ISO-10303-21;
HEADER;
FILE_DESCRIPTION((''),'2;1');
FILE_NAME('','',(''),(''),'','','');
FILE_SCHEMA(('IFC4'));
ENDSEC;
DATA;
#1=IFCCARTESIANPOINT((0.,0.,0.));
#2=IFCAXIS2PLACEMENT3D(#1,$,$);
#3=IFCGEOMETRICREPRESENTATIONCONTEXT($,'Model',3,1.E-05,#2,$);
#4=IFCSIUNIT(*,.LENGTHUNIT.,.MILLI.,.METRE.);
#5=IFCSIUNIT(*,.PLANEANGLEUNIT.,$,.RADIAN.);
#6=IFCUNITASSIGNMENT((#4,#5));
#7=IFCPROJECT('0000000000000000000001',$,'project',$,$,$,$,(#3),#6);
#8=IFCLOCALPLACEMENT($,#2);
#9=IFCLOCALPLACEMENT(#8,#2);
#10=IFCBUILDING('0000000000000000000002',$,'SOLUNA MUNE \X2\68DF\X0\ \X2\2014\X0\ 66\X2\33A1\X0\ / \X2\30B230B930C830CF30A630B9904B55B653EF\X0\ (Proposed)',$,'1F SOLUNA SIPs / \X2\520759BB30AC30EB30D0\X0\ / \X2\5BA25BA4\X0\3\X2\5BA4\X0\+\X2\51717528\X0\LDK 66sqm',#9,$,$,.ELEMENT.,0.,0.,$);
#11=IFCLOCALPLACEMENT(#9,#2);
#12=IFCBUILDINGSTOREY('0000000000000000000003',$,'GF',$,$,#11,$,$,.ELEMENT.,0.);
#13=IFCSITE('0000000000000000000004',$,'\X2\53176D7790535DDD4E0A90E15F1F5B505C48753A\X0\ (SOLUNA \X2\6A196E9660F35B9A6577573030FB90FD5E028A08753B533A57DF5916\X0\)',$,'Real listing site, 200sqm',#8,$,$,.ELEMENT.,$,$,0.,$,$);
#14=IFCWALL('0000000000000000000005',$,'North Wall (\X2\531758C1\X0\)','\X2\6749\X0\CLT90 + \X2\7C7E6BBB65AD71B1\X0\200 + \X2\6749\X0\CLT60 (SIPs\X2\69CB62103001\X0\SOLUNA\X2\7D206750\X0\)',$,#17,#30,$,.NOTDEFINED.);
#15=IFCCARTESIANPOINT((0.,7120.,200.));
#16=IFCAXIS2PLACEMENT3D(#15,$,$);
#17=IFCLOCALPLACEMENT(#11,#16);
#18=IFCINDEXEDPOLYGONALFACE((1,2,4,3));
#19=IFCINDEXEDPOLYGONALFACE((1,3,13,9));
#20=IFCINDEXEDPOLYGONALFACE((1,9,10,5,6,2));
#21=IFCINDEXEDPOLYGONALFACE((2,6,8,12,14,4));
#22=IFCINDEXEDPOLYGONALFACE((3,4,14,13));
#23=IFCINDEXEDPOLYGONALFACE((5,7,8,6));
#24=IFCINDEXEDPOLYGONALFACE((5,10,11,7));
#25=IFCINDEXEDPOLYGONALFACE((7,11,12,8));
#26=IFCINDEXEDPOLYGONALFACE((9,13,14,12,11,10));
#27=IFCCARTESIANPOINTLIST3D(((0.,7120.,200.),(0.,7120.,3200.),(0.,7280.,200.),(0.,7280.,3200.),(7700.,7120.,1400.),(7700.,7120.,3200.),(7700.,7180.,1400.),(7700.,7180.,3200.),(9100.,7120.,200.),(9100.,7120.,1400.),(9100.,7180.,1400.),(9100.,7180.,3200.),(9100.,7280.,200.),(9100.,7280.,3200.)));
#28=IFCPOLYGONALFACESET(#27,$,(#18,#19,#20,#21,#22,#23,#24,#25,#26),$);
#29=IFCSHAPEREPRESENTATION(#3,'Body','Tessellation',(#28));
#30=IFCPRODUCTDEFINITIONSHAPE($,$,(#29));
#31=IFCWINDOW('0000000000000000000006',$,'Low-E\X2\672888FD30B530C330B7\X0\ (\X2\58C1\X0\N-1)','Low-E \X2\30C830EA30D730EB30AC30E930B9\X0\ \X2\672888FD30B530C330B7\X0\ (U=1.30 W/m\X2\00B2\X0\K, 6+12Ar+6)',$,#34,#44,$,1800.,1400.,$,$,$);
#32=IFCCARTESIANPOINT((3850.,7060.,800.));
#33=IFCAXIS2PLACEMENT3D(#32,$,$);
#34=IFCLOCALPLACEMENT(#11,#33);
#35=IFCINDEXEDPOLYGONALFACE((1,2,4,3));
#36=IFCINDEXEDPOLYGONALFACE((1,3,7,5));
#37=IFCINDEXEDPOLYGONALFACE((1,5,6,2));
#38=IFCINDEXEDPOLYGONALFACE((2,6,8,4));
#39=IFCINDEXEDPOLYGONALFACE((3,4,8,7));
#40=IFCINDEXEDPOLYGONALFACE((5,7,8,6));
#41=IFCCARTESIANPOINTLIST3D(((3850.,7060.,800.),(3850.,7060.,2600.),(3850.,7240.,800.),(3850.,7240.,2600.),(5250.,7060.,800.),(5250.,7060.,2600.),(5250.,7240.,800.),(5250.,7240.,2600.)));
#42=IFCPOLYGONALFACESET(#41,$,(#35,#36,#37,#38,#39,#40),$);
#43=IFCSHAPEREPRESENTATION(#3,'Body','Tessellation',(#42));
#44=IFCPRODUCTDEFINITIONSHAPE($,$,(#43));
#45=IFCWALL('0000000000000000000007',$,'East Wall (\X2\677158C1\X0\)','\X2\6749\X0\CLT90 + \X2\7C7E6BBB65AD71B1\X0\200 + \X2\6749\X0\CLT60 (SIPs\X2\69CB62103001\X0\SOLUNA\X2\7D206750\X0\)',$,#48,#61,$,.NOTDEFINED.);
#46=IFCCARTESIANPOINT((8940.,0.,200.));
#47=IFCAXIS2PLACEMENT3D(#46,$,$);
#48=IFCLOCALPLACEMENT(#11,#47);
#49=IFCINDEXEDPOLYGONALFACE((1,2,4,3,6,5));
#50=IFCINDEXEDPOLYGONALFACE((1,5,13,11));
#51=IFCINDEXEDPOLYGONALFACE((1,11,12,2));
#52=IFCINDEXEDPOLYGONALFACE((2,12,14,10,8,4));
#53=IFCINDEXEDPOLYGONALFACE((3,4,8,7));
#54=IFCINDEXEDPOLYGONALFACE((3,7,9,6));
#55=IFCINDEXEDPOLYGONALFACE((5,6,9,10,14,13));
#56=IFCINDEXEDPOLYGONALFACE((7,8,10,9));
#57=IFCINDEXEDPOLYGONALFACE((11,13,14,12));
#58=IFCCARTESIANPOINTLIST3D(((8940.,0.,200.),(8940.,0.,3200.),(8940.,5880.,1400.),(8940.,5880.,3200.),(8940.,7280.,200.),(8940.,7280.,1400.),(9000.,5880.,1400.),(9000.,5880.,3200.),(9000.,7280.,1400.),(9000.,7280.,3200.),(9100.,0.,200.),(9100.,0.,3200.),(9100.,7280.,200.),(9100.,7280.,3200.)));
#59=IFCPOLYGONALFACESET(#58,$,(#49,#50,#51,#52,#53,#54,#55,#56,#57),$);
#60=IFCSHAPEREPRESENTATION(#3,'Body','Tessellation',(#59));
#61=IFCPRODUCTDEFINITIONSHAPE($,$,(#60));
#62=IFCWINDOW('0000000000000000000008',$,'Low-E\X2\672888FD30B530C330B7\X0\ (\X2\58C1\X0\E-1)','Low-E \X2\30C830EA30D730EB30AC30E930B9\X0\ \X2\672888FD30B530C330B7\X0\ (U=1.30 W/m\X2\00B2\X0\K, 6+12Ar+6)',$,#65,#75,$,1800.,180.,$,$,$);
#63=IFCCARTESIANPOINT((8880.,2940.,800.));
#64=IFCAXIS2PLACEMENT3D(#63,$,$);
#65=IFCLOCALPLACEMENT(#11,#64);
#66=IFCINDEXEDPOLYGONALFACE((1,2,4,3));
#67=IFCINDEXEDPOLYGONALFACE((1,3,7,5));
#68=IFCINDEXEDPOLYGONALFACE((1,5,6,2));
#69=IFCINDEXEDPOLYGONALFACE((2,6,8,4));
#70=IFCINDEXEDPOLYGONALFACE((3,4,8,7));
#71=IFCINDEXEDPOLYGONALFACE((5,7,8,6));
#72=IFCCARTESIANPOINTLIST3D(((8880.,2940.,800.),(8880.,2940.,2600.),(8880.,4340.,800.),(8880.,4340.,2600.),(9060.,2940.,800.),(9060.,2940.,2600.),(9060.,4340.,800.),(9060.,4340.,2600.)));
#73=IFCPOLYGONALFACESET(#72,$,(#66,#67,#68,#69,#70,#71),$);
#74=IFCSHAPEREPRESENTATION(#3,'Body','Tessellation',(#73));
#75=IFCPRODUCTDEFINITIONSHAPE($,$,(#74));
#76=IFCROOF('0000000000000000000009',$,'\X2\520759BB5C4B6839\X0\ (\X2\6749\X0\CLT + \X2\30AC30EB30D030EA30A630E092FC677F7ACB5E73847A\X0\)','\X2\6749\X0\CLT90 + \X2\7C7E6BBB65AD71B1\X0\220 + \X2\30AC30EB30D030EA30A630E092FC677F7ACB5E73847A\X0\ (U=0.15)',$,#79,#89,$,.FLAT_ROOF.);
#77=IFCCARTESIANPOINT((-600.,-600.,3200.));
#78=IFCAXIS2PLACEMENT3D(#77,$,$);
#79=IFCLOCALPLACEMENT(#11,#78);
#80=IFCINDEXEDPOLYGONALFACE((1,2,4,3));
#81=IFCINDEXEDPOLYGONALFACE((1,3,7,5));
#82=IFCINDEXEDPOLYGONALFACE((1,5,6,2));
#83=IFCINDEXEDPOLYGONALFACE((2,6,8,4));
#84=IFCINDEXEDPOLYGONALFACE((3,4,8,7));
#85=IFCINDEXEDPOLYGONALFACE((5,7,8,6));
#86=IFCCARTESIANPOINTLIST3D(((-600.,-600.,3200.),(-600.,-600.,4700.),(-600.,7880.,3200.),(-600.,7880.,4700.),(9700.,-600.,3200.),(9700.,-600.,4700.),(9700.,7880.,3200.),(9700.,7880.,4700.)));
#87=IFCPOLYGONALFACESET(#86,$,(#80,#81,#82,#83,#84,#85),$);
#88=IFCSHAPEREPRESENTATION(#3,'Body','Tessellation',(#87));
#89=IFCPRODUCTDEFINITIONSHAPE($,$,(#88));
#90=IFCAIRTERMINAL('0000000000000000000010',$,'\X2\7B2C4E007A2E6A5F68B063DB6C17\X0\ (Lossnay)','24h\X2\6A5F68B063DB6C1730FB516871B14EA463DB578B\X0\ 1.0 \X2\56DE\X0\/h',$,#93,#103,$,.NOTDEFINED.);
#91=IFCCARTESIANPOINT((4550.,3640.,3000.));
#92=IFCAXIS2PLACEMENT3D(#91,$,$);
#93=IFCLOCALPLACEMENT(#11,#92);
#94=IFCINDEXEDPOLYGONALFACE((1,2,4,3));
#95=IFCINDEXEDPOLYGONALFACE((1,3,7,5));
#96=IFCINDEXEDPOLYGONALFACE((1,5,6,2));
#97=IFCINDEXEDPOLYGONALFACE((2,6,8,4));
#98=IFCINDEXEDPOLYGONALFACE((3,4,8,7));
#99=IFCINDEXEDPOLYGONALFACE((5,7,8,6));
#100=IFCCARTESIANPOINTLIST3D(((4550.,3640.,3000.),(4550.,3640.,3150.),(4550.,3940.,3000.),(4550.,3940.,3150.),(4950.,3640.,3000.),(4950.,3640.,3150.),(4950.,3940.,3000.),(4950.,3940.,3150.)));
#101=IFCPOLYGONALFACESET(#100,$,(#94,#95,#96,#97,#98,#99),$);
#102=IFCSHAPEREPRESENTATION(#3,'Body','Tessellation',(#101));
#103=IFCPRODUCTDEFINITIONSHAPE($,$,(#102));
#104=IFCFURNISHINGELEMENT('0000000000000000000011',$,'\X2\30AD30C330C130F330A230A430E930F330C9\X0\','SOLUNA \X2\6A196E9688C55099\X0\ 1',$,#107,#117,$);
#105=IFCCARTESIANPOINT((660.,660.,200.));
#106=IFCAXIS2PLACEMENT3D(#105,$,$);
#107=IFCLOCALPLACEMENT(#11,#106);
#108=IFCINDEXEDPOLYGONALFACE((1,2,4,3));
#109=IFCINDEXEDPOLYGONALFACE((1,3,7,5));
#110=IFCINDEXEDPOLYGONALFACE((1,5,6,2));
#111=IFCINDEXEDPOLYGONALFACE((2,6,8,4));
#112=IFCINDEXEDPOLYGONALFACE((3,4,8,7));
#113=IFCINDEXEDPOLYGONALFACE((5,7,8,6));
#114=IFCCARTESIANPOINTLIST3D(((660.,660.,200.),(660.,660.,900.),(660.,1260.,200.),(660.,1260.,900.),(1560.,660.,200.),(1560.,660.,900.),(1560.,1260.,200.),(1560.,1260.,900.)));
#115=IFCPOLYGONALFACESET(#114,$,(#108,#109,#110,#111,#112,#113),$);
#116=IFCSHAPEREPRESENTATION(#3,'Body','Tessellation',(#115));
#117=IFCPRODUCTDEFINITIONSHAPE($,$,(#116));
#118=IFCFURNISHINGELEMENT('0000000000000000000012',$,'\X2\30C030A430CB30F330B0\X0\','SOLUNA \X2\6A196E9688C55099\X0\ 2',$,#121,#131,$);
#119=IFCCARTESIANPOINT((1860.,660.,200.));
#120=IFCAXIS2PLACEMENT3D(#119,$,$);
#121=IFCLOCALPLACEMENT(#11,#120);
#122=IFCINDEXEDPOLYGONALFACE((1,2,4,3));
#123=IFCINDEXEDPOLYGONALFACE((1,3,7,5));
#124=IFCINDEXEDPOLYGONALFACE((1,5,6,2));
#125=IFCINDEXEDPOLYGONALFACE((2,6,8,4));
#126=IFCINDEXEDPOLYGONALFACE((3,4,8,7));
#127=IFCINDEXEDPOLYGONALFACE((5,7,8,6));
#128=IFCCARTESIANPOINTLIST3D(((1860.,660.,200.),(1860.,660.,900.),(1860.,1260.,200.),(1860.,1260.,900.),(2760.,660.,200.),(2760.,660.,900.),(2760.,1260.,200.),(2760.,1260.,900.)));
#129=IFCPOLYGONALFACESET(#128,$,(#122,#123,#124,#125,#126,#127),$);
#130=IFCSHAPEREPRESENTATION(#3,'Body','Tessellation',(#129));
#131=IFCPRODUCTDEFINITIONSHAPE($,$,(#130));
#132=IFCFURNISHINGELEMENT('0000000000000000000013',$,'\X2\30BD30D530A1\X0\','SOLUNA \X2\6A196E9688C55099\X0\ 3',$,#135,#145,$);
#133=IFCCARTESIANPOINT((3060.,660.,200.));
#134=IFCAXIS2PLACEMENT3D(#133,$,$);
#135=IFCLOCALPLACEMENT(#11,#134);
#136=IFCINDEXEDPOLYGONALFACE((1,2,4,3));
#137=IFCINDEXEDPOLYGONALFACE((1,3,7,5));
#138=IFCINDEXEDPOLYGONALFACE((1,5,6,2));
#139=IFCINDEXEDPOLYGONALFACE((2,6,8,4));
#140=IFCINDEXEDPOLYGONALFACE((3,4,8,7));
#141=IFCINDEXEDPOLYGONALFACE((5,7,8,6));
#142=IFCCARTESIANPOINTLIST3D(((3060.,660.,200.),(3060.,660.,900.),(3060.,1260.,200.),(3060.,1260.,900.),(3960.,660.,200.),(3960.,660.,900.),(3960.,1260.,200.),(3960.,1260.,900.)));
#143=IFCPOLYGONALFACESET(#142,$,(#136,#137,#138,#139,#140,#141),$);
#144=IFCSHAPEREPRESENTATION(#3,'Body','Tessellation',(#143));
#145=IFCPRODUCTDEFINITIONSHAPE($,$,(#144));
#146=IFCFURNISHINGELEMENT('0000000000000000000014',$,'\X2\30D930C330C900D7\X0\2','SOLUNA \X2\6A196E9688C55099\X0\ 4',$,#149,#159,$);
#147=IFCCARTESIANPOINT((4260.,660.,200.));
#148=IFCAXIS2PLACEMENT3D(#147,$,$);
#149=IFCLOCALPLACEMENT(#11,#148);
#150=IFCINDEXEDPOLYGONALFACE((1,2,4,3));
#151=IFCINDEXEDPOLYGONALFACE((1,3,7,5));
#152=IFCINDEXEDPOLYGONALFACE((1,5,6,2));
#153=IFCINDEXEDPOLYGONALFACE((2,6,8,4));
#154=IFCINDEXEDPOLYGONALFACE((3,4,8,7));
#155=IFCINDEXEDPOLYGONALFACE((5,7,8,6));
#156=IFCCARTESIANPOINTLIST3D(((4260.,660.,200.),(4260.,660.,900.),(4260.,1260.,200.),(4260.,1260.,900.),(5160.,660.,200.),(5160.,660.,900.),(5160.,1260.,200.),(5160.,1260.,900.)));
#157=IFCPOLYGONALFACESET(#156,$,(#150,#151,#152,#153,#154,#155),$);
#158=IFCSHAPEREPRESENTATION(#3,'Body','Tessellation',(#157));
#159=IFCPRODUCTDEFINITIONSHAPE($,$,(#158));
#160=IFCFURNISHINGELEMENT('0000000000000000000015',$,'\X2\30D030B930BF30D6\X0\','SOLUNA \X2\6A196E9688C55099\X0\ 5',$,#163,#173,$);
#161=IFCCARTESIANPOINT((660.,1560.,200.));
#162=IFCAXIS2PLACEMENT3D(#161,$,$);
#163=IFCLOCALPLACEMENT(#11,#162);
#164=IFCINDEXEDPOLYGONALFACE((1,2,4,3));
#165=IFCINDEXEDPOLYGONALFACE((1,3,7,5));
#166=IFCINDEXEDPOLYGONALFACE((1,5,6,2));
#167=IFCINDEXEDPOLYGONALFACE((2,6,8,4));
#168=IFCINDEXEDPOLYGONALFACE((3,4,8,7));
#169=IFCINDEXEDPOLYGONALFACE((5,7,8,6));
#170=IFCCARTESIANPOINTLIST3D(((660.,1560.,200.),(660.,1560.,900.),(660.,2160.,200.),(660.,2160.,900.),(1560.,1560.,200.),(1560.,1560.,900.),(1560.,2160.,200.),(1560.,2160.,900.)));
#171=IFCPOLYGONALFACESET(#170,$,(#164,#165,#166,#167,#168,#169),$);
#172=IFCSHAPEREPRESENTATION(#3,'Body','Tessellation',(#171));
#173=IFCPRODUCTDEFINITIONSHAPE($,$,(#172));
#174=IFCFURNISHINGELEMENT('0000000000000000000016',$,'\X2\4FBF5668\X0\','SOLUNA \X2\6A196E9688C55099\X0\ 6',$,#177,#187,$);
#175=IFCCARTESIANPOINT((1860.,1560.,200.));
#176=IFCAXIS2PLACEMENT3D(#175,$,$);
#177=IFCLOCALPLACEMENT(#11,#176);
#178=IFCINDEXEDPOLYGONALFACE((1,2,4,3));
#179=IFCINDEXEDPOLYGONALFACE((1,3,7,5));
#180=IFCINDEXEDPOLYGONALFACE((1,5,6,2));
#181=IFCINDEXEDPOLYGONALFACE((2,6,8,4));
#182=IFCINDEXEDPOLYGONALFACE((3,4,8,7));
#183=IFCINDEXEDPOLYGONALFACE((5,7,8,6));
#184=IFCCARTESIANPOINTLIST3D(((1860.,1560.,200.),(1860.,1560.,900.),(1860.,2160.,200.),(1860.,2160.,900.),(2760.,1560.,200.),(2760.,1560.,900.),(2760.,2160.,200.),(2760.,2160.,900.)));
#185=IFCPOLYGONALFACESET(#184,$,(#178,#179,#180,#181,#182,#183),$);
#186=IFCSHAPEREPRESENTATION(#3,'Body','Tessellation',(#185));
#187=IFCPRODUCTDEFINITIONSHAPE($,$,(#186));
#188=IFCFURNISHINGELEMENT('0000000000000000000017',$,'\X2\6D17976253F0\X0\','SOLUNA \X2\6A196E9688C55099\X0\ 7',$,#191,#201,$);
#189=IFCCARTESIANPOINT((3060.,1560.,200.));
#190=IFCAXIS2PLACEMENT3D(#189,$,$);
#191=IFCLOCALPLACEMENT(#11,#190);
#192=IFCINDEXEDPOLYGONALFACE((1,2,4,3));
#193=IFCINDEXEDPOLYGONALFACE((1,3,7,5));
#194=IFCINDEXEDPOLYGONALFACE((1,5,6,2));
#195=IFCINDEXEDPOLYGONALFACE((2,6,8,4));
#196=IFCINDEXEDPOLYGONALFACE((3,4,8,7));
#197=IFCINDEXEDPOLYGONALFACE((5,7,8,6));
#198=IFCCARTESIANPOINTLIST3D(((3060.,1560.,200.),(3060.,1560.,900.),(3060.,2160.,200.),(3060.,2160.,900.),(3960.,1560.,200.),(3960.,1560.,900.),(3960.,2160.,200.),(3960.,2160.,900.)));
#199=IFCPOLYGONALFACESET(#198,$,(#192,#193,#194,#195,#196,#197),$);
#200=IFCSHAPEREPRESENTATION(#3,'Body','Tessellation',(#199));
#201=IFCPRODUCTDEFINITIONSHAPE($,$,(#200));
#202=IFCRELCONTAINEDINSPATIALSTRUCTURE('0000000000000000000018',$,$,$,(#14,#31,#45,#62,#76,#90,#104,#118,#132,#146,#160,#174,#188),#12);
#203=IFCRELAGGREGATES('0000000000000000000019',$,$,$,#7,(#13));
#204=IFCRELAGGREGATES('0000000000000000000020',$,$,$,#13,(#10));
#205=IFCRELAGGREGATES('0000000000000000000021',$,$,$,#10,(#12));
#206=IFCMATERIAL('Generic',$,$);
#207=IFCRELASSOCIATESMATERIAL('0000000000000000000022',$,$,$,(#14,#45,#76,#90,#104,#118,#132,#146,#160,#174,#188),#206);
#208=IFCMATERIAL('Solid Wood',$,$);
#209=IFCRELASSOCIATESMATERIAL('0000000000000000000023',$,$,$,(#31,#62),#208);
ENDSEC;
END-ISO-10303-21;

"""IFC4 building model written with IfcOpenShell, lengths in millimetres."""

from ifc_helpers import new_model, si_unit, frame, frame_2d, origin, place, context, project, spatial, rectangle, extrude, material, element, fill, save


model = new_model("IFC4")

# Units and contexts
model_context = context("Model", 3, precision=1e-05, world=origin())
ifc_project = project(units=[si_unit("LENGTHUNIT", "METRE", prefix="MILLI"), si_unit("PLANEANGLEUNIT", "RADIAN")], contexts=[model_context])

# Site, building, storey
site_placement = place(None, origin())
site = spatial("IfcSite", under=ifc_project, at=site_placement, Name="北海道川上郡弟子屈町 (SOLUNA 標準想定敷地・都市計画区域外)", ObjectType="Real listing site, 200sqm", CompositionType="ELEMENT", RefElevation=0.0)
building_placement = place(site_placement, origin())
building = spatial("IfcBuilding", under=site, at=building_placement, Name="SOLUNA MUNE 棟 — 66㎡ / ゲストハウス運営可 (Proposed)", ObjectType="1F SOLUNA SIPs / 切妻ガルバ / 客室3室+共用LDK 66sqm", CompositionType="ELEMENT", ElevationOfRefHeight=0.0, ElevationOfTerrain=0.0)
storey_placement = place(building_placement, origin())
storey = spatial("IfcBuildingStorey", under=building, at=storey_placement, Name="GF", CompositionType="ELEMENT", Elevation=0.0)

# Shared definitions
ifc_material_1 = material(Name="Generic")

# Shared definitions
ifc_material_2 = material(Name="Solid Wood")

# Walls, openings, windows
wall_1_placement = place(storey_placement, frame((0.0, 7120.0, 200.0)))
wall_1 = element("IfcWall", 1, at=wall_1_placement, inside=storey, material=ifc_material_1, Name="North Wall (北壁)", Description="杉CLT90 + 籾殻断熱200 + 杉CLT60 (SIPs構成、SOLUNA素材)", PredefinedType="NOTDEFINED", context=model_context, shape_type="SweptSolid", body=[
    extrude(rectangle(XDim=9100.0, YDim=160.0, at=frame_2d((4550.0, 80.0))), frame((0.0, 7120.0, 200.0)), (0.0, 0.0, 1.0), 3000.0),
])
opening_1_placement = place(storey_placement, frame((3850.0, 7060.0, 800.0)))
opening_1 = element("IfcOpeningElement", 2, at=opening_1_placement, cuts=wall_1, PredefinedType="NOTDEFINED", context=model_context, shape_type="SweptSolid", body=[
    extrude(rectangle(XDim=1400.0, YDim=180.0, at=frame_2d((700.0, 90.0))), frame((3850.0, 7060.0, 800.0)), (0.0, 0.0, 1.0), 1800.0),
])
window_1_placement = place(storey_placement, frame((3850.0, 7060.0, 800.0)))
window_1 = element("IfcWindow", 3, at=window_1_placement, inside=storey, material=ifc_material_2, Name="Low-E木製サッシ (壁N-1)", Description="Low-E トリプルガラス 木製サッシ (U=1.30 W/m²K, 6+12Ar+6)", OverallHeight=1800.0, OverallWidth=1400.0, context=model_context, shape_type="SweptSolid", body=[
    extrude(rectangle(XDim=1400.0, YDim=180.0, at=frame_2d((700.0, 90.0))), frame((3850.0, 7060.0, 800.0)), (0.0, 0.0, 1.0), 1800.0),
])
fill(opening_1, window_1)
wall_2_placement = place(storey_placement, frame((8940.0, 0.0, 200.0)))
wall_2 = element("IfcWall", 4, at=wall_2_placement, inside=storey, material=ifc_material_1, Name="East Wall (東壁)", Description="杉CLT90 + 籾殻断熱200 + 杉CLT60 (SIPs構成、SOLUNA素材)", PredefinedType="NOTDEFINED", context=model_context, shape_type="SweptSolid", body=[
    extrude(rectangle(XDim=160.0, YDim=7280.0, at=frame_2d((80.0, 3640.0))), frame((8940.0, 0.0, 200.0)), (0.0, 0.0, 1.0), 3000.0),
])
opening_2_placement = place(storey_placement, frame((8880.0, 2940.0, 800.0)))
opening_2 = element("IfcOpeningElement", 5, at=opening_2_placement, cuts=wall_2, PredefinedType="NOTDEFINED", context=model_context, shape_type="SweptSolid", body=[
    extrude(rectangle(XDim=180.0, YDim=1400.0, at=frame_2d((90.0, 700.0))), frame((8880.0, 2940.0, 800.0)), (0.0, 0.0, 1.0), 1800.0),
])
window_2_placement = place(storey_placement, frame((8880.0, 2940.0, 800.0)))
window_2 = element("IfcWindow", 6, at=window_2_placement, inside=storey, material=ifc_material_2, Name="Low-E木製サッシ (壁E-1)", Description="Low-E トリプルガラス 木製サッシ (U=1.30 W/m²K, 6+12Ar+6)", OverallHeight=1800.0, OverallWidth=180.0, context=model_context, shape_type="SweptSolid", body=[
    extrude(rectangle(XDim=180.0, YDim=1400.0, at=frame_2d((90.0, 700.0))), frame((8880.0, 2940.0, 800.0)), (0.0, 0.0, 1.0), 1800.0),
])
fill(opening_2, window_2)

# Roof
roof_placement = place(storey_placement, frame((-600.0, -600.0, 3200.0)))
element("IfcRoof", 7, at=roof_placement, inside=storey, material=ifc_material_1, Name="切妻屋根 (杉CLT + ガルバリウム鋼板立平葺)", Description="杉CLT90 + 籾殻断熱220 + ガルバリウム鋼板立平葺 (U=0.15)", PredefinedType="FLAT_ROOF", context=model_context, shape_type="SweptSolid", body=[
    extrude(rectangle(XDim=10300.0, YDim=8480.0, at=frame_2d((5150.0, 4240.0))), frame((-600.0, -600.0, 3200.0)), (0.0, 0.0, 1.0), 1500.0),
])

# Air terminal
air_terminal_placement = place(storey_placement, frame((4550.0, 3640.0, 3000.0)))
element("IfcAirTerminal", 8, at=air_terminal_placement, inside=storey, material=ifc_material_1, Name="第一種機械換気 (Lossnay)", Description="24h機械換気・全熱交換型 1.0 回/h", PredefinedType="NOTDEFINED", context=model_context, shape_type="SweptSolid", body=[
    extrude(rectangle(XDim=400.0, YDim=300.0, at=frame_2d((200.0, 150.0))), frame((4550.0, 3640.0, 3000.0)), (0.0, 0.0, 1.0), 150.0),
])

# Furnishing elements
furnishing_1_placement = place(storey_placement, frame((660.0, 660.0, 200.0)))
element("IfcFurnishingElement", 9, at=furnishing_1_placement, inside=storey, material=ifc_material_1, Name="キッチンアイランド", Description="SOLUNA 標準装備 1", context=model_context, shape_type="SweptSolid", body=[
    extrude(rectangle(XDim=900.0, YDim=600.0, at=frame_2d((450.0, 300.0))), frame((660.0, 660.0, 200.0)), (0.0, 0.0, 1.0), 700.0),
])
furnishing_2_placement = place(storey_placement, frame((1860.0, 660.0, 200.0)))
element("IfcFurnishingElement", 10, at=furnishing_2_placement, inside=storey, material=ifc_material_1, Name="ダイニング", Description="SOLUNA 標準装備 2", context=model_context, shape_type="SweptSolid", body=[
    extrude(rectangle(XDim=900.0, YDim=600.0, at=frame_2d((450.0, 300.0))), frame((1860.0, 660.0, 200.0)), (0.0, 0.0, 1.0), 700.0),
])
furnishing_3_placement = place(storey_placement, frame((3060.0, 660.0, 200.0)))
element("IfcFurnishingElement", 11, at=furnishing_3_placement, inside=storey, material=ifc_material_1, Name="ソファ", Description="SOLUNA 標準装備 3", context=model_context, shape_type="SweptSolid", body=[
    extrude(rectangle(XDim=900.0, YDim=600.0, at=frame_2d((450.0, 300.0))), frame((3060.0, 660.0, 200.0)), (0.0, 0.0, 1.0), 700.0),
])
furnishing_4_placement = place(storey_placement, frame((4260.0, 660.0, 200.0)))
element("IfcFurnishingElement", 12, at=furnishing_4_placement, inside=storey, material=ifc_material_1, Name="ベッド×2", Description="SOLUNA 標準装備 4", context=model_context, shape_type="SweptSolid", body=[
    extrude(rectangle(XDim=900.0, YDim=600.0, at=frame_2d((450.0, 300.0))), frame((4260.0, 660.0, 200.0)), (0.0, 0.0, 1.0), 700.0),
])
furnishing_5_placement = place(storey_placement, frame((660.0, 1560.0, 200.0)))
element("IfcFurnishingElement", 13, at=furnishing_5_placement, inside=storey, material=ifc_material_1, Name="バスタブ", Description="SOLUNA 標準装備 5", context=model_context, shape_type="SweptSolid", body=[
    extrude(rectangle(XDim=900.0, YDim=600.0, at=frame_2d((450.0, 300.0))), frame((660.0, 1560.0, 200.0)), (0.0, 0.0, 1.0), 700.0),
])
furnishing_6_placement = place(storey_placement, frame((1860.0, 1560.0, 200.0)))
element("IfcFurnishingElement", 14, at=furnishing_6_placement, inside=storey, material=ifc_material_1, Name="便器", Description="SOLUNA 標準装備 6", context=model_context, shape_type="SweptSolid", body=[
    extrude(rectangle(XDim=900.0, YDim=600.0, at=frame_2d((450.0, 300.0))), frame((1860.0, 1560.0, 200.0)), (0.0, 0.0, 1.0), 700.0),
])
furnishing_7_placement = place(storey_placement, frame((3060.0, 1560.0, 200.0)))
element("IfcFurnishingElement", 15, at=furnishing_7_placement, inside=storey, material=ifc_material_1, Name="洗面台", Description="SOLUNA 標準装備 7", context=model_context, shape_type="SweptSolid", body=[
    extrude(rectangle(XDim=900.0, YDim=600.0, at=frame_2d((450.0, 300.0))), frame((3060.0, 1560.0, 200.0)), (0.0, 0.0, 1.0), 700.0),
])

save(model, "model.ifc")
